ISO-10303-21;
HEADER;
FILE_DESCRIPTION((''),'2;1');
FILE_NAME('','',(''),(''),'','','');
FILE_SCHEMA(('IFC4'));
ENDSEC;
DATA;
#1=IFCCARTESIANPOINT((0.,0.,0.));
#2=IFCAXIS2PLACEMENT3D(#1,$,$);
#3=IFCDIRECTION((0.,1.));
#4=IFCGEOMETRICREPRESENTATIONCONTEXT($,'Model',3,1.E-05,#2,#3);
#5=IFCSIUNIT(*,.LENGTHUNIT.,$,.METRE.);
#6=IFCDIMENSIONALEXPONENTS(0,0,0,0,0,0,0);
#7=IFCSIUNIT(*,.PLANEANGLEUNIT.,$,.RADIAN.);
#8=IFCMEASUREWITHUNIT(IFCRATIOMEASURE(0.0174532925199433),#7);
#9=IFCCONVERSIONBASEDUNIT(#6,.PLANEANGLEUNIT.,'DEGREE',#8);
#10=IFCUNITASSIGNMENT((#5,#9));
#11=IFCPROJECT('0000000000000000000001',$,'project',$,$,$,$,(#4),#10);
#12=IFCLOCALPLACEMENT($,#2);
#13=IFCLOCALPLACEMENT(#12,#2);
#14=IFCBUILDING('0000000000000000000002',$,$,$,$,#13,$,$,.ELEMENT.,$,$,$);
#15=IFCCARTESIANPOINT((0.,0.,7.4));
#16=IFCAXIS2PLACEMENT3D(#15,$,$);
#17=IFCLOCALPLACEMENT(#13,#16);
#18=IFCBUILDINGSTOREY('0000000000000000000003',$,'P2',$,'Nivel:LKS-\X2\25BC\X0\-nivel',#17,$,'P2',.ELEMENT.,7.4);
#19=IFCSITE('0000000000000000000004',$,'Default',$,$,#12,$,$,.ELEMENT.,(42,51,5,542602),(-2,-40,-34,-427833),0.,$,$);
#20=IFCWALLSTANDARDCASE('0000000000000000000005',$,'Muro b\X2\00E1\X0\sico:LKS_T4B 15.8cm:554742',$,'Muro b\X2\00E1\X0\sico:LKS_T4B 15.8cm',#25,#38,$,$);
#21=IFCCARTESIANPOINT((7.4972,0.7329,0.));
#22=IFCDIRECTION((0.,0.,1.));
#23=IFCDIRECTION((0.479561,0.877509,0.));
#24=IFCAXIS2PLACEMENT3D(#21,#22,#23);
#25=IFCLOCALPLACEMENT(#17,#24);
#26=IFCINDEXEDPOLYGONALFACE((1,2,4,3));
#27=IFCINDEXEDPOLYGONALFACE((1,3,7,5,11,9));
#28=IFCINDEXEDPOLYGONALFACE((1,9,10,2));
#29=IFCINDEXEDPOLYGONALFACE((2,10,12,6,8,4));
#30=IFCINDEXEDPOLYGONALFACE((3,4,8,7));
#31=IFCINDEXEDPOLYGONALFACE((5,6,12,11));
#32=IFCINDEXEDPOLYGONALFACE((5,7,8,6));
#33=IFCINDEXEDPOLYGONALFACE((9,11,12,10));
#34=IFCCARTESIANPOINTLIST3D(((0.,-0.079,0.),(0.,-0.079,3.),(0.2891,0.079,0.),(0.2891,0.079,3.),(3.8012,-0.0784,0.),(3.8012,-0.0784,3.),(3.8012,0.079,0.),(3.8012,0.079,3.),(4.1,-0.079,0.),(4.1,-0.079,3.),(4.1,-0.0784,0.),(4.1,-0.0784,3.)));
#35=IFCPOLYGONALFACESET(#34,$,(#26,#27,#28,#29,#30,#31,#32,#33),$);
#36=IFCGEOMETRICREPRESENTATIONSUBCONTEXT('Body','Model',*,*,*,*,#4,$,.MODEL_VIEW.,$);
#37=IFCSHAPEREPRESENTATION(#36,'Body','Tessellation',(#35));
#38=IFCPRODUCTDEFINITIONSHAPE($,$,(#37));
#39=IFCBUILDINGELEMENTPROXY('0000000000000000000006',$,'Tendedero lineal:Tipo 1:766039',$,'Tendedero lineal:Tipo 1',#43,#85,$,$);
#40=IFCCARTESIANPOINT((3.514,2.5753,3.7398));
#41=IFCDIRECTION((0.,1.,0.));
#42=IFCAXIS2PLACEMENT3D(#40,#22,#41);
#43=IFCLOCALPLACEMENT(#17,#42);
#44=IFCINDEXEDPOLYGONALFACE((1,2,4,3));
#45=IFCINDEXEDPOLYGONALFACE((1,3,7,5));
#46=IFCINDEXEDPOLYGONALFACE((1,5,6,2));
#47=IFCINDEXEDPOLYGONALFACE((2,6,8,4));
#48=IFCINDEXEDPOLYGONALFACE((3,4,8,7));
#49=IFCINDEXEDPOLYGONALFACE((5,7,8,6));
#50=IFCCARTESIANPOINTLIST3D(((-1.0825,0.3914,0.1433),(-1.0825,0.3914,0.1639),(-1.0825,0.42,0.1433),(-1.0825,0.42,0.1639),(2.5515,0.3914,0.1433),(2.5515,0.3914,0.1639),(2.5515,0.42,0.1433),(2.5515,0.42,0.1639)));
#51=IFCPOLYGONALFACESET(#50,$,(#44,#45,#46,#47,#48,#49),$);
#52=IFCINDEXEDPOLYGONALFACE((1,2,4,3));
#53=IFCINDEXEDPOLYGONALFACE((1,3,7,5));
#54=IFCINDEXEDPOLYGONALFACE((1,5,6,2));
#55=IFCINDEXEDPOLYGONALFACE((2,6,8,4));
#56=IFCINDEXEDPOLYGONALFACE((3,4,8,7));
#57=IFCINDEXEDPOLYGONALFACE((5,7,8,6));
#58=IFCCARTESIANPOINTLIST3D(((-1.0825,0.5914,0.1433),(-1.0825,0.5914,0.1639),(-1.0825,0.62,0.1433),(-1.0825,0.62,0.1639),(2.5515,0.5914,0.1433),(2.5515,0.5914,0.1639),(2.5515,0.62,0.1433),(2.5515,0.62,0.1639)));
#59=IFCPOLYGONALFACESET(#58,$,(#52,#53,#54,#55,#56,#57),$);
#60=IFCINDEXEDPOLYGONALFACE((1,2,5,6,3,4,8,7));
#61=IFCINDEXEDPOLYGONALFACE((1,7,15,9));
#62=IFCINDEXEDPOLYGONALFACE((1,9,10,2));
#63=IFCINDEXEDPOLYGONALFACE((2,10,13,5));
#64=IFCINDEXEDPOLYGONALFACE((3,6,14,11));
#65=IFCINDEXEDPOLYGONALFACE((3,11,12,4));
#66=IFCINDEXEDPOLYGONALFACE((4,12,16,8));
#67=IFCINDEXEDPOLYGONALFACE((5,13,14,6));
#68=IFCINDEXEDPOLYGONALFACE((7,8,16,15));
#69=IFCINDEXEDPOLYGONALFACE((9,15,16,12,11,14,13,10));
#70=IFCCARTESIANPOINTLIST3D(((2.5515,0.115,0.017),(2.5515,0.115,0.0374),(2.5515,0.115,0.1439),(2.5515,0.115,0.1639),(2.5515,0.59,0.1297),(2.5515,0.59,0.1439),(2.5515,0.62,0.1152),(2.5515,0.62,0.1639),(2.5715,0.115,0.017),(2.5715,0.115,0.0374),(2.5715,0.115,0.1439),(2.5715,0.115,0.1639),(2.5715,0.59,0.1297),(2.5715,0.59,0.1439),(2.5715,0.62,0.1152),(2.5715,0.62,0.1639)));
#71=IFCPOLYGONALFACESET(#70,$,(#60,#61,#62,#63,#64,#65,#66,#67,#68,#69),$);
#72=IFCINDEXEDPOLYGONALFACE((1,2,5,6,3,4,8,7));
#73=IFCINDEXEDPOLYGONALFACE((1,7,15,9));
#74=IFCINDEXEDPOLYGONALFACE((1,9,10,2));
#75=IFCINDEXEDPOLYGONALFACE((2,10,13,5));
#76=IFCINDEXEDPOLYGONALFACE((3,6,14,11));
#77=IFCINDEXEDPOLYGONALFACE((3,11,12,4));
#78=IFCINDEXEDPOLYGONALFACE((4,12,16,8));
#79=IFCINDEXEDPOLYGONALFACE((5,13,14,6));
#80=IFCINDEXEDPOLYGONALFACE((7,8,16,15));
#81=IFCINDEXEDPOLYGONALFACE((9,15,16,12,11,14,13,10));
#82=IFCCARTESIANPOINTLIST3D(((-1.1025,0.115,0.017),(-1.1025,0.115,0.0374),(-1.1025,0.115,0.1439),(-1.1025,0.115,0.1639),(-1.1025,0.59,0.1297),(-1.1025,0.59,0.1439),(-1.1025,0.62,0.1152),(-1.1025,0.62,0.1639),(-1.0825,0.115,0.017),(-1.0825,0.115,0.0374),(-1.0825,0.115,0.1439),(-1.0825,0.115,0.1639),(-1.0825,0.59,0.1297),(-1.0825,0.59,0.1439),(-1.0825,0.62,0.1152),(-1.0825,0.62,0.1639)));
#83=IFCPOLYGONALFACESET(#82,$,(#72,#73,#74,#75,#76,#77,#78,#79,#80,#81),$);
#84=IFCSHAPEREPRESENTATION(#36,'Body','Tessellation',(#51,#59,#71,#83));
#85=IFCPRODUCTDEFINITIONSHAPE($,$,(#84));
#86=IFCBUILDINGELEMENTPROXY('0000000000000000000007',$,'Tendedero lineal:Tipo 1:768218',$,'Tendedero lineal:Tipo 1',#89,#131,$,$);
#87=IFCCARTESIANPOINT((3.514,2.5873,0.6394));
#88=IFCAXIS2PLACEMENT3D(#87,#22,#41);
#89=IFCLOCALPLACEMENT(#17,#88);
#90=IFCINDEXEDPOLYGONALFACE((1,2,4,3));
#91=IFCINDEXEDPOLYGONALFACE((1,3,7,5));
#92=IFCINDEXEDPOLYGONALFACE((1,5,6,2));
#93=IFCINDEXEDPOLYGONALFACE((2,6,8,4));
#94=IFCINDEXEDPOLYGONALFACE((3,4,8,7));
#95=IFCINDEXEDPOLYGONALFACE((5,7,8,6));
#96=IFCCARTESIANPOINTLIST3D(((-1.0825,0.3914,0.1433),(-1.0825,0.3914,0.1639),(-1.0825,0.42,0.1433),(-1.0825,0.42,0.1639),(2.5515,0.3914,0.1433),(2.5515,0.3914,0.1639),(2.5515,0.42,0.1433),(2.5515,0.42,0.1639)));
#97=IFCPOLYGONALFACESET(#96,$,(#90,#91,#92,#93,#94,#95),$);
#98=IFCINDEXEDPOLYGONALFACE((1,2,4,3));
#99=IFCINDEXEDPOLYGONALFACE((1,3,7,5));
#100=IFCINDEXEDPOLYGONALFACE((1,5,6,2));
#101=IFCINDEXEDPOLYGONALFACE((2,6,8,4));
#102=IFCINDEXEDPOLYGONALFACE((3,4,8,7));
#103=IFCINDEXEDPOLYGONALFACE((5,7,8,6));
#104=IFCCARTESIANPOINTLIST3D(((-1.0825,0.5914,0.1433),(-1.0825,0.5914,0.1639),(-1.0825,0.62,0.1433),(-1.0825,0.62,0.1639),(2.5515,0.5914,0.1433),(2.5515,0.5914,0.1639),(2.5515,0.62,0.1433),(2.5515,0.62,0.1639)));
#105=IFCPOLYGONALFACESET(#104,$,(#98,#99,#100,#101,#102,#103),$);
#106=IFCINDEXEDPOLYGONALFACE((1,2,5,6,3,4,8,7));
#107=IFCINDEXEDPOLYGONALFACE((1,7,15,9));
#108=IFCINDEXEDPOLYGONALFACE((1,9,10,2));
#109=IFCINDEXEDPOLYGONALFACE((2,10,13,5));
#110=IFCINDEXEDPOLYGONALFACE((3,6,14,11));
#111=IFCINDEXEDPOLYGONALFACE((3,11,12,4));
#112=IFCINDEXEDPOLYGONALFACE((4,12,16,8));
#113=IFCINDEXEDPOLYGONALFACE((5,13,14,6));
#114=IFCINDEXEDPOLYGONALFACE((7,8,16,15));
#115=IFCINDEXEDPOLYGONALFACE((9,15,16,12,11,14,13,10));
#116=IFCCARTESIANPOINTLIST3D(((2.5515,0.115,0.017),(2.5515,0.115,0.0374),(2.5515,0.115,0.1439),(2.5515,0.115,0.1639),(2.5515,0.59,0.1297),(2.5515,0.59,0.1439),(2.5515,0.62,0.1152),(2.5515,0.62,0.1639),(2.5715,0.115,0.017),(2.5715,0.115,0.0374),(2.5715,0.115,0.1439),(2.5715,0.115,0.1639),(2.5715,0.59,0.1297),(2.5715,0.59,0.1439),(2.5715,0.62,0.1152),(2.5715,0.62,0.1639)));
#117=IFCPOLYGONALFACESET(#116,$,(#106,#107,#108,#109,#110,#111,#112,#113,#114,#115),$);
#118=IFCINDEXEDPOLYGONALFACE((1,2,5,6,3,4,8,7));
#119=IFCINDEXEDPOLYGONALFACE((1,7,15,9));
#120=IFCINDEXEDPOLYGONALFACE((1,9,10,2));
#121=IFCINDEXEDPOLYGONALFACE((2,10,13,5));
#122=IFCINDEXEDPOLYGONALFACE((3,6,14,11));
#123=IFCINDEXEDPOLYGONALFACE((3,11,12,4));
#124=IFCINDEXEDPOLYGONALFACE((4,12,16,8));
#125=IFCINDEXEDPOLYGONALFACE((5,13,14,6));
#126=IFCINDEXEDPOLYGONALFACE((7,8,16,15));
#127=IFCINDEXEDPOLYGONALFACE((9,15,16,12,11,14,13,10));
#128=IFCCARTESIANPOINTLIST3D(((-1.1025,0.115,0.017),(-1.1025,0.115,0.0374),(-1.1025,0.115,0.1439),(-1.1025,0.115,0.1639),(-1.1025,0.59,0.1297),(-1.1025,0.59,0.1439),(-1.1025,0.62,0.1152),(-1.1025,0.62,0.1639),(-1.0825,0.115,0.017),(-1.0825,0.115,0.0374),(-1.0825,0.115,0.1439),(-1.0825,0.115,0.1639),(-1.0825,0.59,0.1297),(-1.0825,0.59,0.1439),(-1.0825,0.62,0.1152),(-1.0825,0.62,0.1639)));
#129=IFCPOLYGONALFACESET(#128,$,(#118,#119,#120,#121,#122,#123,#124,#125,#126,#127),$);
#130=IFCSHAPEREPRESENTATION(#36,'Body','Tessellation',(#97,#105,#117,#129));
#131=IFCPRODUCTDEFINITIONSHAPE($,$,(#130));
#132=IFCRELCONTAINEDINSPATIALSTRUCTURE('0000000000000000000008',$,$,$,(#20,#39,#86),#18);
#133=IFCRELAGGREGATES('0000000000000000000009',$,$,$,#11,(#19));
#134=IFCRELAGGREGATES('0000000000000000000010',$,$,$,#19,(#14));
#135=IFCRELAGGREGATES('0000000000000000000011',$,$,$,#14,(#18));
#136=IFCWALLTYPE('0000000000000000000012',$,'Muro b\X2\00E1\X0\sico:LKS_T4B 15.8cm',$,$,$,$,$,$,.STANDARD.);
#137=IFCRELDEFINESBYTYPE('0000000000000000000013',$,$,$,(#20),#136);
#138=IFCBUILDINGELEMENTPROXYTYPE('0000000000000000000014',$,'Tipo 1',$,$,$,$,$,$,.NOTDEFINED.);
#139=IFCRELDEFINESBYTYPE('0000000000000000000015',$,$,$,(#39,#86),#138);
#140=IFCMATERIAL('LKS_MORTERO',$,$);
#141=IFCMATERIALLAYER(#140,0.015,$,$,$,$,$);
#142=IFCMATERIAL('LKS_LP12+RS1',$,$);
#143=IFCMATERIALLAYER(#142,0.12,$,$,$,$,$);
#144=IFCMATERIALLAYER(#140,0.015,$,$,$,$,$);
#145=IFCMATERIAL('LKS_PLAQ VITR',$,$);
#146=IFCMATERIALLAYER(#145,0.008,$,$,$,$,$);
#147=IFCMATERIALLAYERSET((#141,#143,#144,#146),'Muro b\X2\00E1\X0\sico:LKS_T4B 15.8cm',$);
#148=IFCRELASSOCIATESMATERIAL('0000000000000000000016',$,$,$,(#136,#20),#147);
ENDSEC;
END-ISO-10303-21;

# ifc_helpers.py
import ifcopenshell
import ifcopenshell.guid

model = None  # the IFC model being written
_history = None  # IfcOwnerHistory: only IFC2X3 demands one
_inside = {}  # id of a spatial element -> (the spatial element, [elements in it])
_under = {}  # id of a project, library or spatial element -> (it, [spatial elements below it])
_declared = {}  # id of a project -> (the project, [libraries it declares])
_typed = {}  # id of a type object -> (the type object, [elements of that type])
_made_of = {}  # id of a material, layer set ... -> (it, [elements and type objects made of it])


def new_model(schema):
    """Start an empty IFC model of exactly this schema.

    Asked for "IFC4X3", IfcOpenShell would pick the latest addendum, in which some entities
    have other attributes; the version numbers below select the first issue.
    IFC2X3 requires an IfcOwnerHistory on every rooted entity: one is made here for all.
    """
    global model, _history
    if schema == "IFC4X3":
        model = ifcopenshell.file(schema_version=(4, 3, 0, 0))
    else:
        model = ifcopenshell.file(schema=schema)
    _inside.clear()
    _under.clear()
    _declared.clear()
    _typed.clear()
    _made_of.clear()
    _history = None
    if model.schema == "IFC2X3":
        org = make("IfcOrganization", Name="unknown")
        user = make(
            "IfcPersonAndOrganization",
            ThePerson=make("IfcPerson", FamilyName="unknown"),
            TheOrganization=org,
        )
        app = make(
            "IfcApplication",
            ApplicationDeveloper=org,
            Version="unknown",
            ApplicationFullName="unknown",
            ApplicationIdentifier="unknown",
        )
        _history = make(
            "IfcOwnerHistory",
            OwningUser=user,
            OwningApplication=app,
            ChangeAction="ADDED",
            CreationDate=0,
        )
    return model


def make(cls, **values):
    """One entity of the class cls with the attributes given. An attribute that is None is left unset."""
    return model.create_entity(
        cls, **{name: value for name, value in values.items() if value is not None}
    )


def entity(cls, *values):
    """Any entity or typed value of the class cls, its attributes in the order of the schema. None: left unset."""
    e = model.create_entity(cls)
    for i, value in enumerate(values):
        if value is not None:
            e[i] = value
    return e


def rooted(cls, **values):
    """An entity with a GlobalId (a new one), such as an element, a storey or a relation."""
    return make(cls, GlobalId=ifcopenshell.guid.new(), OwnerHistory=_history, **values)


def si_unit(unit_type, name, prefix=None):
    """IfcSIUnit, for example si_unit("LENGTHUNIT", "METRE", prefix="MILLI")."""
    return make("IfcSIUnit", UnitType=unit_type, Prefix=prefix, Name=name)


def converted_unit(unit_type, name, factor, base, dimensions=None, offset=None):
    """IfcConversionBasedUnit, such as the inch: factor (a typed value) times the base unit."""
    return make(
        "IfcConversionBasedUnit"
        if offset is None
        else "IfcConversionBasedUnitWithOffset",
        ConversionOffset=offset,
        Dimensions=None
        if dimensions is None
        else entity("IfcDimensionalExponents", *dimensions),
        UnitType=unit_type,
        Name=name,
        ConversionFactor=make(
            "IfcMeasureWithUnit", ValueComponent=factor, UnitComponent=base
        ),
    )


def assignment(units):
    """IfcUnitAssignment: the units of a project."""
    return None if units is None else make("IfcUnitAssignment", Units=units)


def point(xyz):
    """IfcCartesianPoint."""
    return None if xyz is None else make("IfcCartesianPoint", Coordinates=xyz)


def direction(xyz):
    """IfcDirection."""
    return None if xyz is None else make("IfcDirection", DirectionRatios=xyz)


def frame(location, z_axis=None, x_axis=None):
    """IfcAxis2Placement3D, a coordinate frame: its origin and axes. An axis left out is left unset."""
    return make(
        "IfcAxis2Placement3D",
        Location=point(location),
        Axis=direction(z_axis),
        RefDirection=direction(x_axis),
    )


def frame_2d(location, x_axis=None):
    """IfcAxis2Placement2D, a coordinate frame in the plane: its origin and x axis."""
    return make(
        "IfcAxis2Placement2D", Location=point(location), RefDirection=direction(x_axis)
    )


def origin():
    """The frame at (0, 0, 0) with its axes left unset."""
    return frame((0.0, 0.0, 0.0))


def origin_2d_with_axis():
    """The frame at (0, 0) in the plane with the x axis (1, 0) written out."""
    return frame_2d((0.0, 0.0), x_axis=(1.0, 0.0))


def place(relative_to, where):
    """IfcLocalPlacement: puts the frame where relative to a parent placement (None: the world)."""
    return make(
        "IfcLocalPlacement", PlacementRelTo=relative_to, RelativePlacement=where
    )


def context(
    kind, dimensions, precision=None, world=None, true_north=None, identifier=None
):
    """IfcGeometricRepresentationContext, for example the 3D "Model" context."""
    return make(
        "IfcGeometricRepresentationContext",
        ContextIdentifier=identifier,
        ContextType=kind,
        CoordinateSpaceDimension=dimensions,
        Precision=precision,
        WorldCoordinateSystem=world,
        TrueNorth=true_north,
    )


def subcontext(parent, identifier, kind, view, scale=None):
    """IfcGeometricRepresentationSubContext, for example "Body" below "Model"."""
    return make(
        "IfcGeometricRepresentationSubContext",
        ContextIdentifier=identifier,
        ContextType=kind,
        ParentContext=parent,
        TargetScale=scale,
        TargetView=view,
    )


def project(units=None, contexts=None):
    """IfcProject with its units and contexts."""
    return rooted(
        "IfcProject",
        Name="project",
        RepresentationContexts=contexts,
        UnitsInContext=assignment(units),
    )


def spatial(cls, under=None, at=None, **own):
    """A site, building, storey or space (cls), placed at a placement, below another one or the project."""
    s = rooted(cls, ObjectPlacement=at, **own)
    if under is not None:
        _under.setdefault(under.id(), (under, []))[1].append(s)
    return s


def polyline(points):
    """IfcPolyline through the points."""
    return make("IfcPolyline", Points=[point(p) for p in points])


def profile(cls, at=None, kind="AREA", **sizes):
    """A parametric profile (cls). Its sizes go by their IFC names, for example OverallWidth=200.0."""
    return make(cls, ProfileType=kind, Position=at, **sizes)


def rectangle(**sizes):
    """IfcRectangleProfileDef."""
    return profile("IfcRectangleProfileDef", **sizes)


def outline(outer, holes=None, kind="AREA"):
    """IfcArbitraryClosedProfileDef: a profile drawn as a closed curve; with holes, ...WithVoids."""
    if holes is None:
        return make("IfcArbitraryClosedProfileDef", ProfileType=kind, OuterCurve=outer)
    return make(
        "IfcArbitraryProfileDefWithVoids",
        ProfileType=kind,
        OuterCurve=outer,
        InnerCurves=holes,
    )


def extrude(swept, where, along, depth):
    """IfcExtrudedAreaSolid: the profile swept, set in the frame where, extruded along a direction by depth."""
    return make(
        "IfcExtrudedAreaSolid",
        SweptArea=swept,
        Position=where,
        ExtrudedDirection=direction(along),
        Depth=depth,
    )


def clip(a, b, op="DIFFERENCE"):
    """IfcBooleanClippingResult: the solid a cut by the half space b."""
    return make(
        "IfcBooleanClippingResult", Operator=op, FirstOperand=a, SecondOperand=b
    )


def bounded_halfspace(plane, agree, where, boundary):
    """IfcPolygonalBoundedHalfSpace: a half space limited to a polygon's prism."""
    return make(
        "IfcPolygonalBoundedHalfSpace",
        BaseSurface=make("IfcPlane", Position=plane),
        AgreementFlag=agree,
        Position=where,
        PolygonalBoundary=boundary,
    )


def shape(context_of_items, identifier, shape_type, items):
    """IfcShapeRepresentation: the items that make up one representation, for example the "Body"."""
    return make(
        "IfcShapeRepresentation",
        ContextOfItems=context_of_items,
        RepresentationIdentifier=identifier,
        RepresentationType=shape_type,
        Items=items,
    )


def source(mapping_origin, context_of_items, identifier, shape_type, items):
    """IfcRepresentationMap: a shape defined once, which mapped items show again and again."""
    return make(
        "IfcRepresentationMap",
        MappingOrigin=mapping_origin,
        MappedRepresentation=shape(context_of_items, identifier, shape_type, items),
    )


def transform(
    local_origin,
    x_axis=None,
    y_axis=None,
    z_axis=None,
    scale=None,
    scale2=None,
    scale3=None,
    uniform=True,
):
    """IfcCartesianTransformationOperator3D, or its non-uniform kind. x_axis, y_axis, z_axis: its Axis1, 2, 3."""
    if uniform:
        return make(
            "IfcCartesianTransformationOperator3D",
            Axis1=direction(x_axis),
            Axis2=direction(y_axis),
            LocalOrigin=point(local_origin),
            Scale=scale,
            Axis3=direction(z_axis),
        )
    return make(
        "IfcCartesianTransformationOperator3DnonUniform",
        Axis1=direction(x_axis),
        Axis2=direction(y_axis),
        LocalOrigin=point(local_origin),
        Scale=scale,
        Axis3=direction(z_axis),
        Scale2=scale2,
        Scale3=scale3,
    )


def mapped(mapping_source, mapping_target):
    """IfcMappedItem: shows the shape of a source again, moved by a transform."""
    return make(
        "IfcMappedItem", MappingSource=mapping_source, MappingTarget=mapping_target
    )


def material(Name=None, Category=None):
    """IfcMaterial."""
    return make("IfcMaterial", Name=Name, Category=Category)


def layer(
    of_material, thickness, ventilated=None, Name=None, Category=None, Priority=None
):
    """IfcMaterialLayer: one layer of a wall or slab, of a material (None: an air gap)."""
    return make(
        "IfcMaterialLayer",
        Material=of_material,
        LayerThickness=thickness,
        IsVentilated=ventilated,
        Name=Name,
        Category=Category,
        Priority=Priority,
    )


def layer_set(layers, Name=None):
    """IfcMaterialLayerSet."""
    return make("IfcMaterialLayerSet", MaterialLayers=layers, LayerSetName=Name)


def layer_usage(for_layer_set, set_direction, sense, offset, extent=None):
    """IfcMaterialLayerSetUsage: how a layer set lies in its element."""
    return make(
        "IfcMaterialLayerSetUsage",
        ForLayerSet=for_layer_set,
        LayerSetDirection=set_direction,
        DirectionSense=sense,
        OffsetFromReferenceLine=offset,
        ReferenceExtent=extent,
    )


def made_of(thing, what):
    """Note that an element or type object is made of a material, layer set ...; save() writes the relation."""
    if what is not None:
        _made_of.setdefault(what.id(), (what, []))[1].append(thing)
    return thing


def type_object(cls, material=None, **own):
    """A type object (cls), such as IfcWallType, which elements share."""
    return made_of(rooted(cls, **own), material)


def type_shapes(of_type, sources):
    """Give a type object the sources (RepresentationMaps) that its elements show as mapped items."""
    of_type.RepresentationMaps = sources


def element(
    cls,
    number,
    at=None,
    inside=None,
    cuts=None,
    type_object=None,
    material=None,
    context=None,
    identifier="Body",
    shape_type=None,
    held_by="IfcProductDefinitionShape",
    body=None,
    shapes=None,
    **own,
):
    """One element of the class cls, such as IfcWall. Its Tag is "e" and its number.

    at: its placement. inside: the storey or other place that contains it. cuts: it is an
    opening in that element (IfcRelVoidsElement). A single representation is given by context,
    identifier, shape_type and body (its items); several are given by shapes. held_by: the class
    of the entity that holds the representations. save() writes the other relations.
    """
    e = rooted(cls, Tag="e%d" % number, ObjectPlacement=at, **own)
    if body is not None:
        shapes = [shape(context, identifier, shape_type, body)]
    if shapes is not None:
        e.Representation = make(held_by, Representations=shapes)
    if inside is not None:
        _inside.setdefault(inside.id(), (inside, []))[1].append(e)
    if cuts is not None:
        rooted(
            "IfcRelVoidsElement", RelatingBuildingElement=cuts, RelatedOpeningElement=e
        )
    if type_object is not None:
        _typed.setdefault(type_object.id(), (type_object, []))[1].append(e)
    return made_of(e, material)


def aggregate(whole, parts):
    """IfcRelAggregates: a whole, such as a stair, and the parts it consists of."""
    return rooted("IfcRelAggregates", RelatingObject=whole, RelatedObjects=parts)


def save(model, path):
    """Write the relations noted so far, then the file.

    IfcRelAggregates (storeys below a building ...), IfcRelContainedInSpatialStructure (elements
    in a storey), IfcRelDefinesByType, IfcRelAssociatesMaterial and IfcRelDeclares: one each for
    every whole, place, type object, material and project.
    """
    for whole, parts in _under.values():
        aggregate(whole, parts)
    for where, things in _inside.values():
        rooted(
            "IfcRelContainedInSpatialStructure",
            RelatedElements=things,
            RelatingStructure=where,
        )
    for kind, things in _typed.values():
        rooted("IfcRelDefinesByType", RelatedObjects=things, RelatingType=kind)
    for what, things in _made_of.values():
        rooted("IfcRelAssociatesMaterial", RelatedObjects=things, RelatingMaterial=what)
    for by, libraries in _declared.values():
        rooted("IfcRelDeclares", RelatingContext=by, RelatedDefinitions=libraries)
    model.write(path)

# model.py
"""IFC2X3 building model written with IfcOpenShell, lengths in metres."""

from ifc_helpers import new_model, entity, si_unit, converted_unit, direction, frame, origin, origin_2d_with_axis, place, context, subcontext, project, spatial, polyline, rectangle, outline, extrude, clip, bounded_halfspace, source, transform, mapped, material, layer, layer_set, layer_usage, type_object, type_shapes, element, save


model = new_model("IFC2X3")

# Units and contexts
model_context = context("Model", 3, precision=1e-05, world=origin(), true_north=direction((0.0, 1.0)))
body_context = subcontext(model_context, "Body", "Model", "MODEL_VIEW")
ifc_project = project(units=[si_unit("LENGTHUNIT", "METRE"), converted_unit("PLANEANGLEUNIT", "DEGREE", entity("IfcRatioMeasure", 0.0174532925199433), si_unit("PLANEANGLEUNIT", "RADIAN"), dimensions=[0, 0, 0, 0, 0, 0, 0])], contexts=[model_context])

# Site, building, storey
site_placement = place(None, origin())
site = spatial("IfcSite", under=ifc_project, at=site_placement, Name="Default", CompositionType="ELEMENT", RefLatitude=(42, 51, 5, 542602), RefLongitude=(-2, -40, -34, -427833), RefElevation=0.0)
building_placement = place(site_placement, origin())
building = spatial("IfcBuilding", under=site, at=building_placement, CompositionType="ELEMENT")
storey_placement = place(building_placement, frame((0.0, 0.0, 7.4)))
storey = spatial("IfcBuildingStorey", under=building, at=storey_placement, Name="P2", ObjectType="Nivel:LKS-▼-nivel", LongName="P2", CompositionType="ELEMENT", Elevation=7.4)

# Wall
ifc_material_1 = material(Name="LKS_MORTERO")
ifc_layer_1 = layer(ifc_material_1, 0.015)
ifc_material_2 = material(Name="LKS_LP12+RS1")
ifc_layer_2 = layer(ifc_material_2, 0.12)
ifc_layer_3 = layer(ifc_material_1, 0.015)
ifc_material_3 = material(Name="LKS_PLAQ VITR")
ifc_layer_4 = layer(ifc_material_3, 0.008)
ifc_layer_set_1 = layer_set([ifc_layer_1, ifc_layer_2, ifc_layer_3, ifc_layer_4], Name="Muro básico:LKS_T4B 15.8cm")
ifc_layer_usage_1 = layer_usage(ifc_layer_set_1, "AXIS2", "POSITIVE", -0.079)
wall_type_1 = type_object("IfcWallType", Name="Muro básico:LKS_T4B 15.8cm", PredefinedType="STANDARD", material=ifc_layer_set_1)
wall_1_placement = place(storey_placement, frame((7.4972, 0.7329, 0.0), z_axis=(0.0, 0.0, 1.0), x_axis=(0.479561, 0.877509, 0.0)))
element("IfcWallStandardCase", 1, at=wall_1_placement, inside=storey, type_object=wall_type_1, material=ifc_layer_usage_1, Name="Muro básico:LKS_T4B 15.8cm:554742", ObjectType="Muro básico:LKS_T4B 15.8cm", context=body_context, shape_type="Clipping", body=[
    clip(clip(extrude(outline(polyline([(4.1, -0.079), (4.1, -0.0784), (3.8012, -0.0784), (3.8012, 0.079), (1.5591, 0.079), (1.4591, 0.079), (0.2891, 0.079), (0.0, -0.079), (4.1, -0.079)])), origin(), (0.0, 0.0, 1.0), 3.0), bounded_halfspace(frame((3.8012, -0.0784, 0.0), z_axis=(0.0, -1.0, 0.0), x_axis=(0.0, 0.0, -1.0)), True, frame((3.8012, -0.0784, 0.0), z_axis=(0.0, -1.0, 0.0), x_axis=(0.0, 0.0, -1.0)), polyline([(0.0, 0.0), (0.0, 0.2988), (-3.0, 0.2988), (-3.0, 0.0), (0.0, 0.0)]))), bounded_halfspace(frame((3.8012, -0.0784, 3.0), z_axis=(-1.0, 0.0, 0.0), x_axis=(0.0, 0.0, -1.0)), True, frame((3.8012, -0.0784, 3.0), z_axis=(-1.0, 0.0, 0.0), x_axis=(0.0, 0.0, -1.0)), polyline([(0.0, 0.0), (0.0, -0.048), (0.0, -0.1574), (3.0, -0.1574), (3.0, 0.0), (0.0, 0.0)]))),
])

# Building element proxies
building_element_proxy_type_1 = type_object("IfcBuildingElementProxyType", Name="Tipo 1", PredefinedType="NOTDEFINED")
shared_shape_1 = source(origin(), body_context, "Body", "SweptSolid", [
    extrude(rectangle(XDim=3.634, YDim=0.0286, at=origin_2d_with_axis()), frame((0.7345, 0.4057, 0.1433), z_axis=(0.0, 0.0, 1.0), x_axis=(-1.0, 0.0, 0.0)), (0.0, 0.0, 1.0), 0.0206),
    extrude(rectangle(XDim=3.634, YDim=0.0286, at=origin_2d_with_axis()), frame((0.7345, 0.6057, 0.1433), z_axis=(0.0, 0.0, 1.0), x_axis=(-1.0, 0.0, 0.0)), (0.0, 0.0, 1.0), 0.0206),
    extrude(outline(polyline([(-0.26, -0.0495), (0.245, -0.0495), (0.245, -0.0295), (-0.23, -0.0295), (-0.23, -0.0154), (0.245, 0.077), (0.245, 0.0973), (-0.26, -0.0008), (-0.26, -0.0495)])), frame((2.5515, 0.36, 0.1144), z_axis=(1.0, 0.0, 0.0), x_axis=(0.0, -1.0, 0.0)), (0.0, 0.0, 1.0), 0.02),
    extrude(outline(polyline([(-0.26, -0.0495), (0.245, -0.0495), (0.245, -0.0295), (-0.23, -0.0295), (-0.23, -0.0154), (0.245, 0.077), (0.245, 0.0973), (-0.26, -0.0008), (-0.26, -0.0495)])), frame((-1.1025, 0.36, 0.1144), z_axis=(1.0, 0.0, 0.0), x_axis=(0.0, -1.0, 0.0)), (0.0, 0.0, 1.0), 0.02),
])
type_shapes(building_element_proxy_type_1, [shared_shape_1])
for number, where, z_axis, x_axis, name in (
    (2, (3.514, 2.5753, 3.7398), (0.0, 0.0, 1.0), (0.0, 1.0, 0.0), "Tendedero lineal:Tipo 1:766039"),
    (3, (3.514, 2.5873, 0.6394), (0.0, 0.0, 1.0), (0.0, 1.0, 0.0), "Tendedero lineal:Tipo 1:768218"),
):
    element("IfcBuildingElementProxy", number, at=place(storey_placement, frame(where, z_axis=z_axis, x_axis=x_axis)), inside=storey, type_object=building_element_proxy_type_1, Name=name, ObjectType="Tendedero lineal:Tipo 1", context=body_context, shape_type="MappedRepresentation", body=[
        mapped(shared_shape_1, transform((0.0, 0.0, 0.0), scale=1.0)),
    ])

save(model, "model.ifc")
